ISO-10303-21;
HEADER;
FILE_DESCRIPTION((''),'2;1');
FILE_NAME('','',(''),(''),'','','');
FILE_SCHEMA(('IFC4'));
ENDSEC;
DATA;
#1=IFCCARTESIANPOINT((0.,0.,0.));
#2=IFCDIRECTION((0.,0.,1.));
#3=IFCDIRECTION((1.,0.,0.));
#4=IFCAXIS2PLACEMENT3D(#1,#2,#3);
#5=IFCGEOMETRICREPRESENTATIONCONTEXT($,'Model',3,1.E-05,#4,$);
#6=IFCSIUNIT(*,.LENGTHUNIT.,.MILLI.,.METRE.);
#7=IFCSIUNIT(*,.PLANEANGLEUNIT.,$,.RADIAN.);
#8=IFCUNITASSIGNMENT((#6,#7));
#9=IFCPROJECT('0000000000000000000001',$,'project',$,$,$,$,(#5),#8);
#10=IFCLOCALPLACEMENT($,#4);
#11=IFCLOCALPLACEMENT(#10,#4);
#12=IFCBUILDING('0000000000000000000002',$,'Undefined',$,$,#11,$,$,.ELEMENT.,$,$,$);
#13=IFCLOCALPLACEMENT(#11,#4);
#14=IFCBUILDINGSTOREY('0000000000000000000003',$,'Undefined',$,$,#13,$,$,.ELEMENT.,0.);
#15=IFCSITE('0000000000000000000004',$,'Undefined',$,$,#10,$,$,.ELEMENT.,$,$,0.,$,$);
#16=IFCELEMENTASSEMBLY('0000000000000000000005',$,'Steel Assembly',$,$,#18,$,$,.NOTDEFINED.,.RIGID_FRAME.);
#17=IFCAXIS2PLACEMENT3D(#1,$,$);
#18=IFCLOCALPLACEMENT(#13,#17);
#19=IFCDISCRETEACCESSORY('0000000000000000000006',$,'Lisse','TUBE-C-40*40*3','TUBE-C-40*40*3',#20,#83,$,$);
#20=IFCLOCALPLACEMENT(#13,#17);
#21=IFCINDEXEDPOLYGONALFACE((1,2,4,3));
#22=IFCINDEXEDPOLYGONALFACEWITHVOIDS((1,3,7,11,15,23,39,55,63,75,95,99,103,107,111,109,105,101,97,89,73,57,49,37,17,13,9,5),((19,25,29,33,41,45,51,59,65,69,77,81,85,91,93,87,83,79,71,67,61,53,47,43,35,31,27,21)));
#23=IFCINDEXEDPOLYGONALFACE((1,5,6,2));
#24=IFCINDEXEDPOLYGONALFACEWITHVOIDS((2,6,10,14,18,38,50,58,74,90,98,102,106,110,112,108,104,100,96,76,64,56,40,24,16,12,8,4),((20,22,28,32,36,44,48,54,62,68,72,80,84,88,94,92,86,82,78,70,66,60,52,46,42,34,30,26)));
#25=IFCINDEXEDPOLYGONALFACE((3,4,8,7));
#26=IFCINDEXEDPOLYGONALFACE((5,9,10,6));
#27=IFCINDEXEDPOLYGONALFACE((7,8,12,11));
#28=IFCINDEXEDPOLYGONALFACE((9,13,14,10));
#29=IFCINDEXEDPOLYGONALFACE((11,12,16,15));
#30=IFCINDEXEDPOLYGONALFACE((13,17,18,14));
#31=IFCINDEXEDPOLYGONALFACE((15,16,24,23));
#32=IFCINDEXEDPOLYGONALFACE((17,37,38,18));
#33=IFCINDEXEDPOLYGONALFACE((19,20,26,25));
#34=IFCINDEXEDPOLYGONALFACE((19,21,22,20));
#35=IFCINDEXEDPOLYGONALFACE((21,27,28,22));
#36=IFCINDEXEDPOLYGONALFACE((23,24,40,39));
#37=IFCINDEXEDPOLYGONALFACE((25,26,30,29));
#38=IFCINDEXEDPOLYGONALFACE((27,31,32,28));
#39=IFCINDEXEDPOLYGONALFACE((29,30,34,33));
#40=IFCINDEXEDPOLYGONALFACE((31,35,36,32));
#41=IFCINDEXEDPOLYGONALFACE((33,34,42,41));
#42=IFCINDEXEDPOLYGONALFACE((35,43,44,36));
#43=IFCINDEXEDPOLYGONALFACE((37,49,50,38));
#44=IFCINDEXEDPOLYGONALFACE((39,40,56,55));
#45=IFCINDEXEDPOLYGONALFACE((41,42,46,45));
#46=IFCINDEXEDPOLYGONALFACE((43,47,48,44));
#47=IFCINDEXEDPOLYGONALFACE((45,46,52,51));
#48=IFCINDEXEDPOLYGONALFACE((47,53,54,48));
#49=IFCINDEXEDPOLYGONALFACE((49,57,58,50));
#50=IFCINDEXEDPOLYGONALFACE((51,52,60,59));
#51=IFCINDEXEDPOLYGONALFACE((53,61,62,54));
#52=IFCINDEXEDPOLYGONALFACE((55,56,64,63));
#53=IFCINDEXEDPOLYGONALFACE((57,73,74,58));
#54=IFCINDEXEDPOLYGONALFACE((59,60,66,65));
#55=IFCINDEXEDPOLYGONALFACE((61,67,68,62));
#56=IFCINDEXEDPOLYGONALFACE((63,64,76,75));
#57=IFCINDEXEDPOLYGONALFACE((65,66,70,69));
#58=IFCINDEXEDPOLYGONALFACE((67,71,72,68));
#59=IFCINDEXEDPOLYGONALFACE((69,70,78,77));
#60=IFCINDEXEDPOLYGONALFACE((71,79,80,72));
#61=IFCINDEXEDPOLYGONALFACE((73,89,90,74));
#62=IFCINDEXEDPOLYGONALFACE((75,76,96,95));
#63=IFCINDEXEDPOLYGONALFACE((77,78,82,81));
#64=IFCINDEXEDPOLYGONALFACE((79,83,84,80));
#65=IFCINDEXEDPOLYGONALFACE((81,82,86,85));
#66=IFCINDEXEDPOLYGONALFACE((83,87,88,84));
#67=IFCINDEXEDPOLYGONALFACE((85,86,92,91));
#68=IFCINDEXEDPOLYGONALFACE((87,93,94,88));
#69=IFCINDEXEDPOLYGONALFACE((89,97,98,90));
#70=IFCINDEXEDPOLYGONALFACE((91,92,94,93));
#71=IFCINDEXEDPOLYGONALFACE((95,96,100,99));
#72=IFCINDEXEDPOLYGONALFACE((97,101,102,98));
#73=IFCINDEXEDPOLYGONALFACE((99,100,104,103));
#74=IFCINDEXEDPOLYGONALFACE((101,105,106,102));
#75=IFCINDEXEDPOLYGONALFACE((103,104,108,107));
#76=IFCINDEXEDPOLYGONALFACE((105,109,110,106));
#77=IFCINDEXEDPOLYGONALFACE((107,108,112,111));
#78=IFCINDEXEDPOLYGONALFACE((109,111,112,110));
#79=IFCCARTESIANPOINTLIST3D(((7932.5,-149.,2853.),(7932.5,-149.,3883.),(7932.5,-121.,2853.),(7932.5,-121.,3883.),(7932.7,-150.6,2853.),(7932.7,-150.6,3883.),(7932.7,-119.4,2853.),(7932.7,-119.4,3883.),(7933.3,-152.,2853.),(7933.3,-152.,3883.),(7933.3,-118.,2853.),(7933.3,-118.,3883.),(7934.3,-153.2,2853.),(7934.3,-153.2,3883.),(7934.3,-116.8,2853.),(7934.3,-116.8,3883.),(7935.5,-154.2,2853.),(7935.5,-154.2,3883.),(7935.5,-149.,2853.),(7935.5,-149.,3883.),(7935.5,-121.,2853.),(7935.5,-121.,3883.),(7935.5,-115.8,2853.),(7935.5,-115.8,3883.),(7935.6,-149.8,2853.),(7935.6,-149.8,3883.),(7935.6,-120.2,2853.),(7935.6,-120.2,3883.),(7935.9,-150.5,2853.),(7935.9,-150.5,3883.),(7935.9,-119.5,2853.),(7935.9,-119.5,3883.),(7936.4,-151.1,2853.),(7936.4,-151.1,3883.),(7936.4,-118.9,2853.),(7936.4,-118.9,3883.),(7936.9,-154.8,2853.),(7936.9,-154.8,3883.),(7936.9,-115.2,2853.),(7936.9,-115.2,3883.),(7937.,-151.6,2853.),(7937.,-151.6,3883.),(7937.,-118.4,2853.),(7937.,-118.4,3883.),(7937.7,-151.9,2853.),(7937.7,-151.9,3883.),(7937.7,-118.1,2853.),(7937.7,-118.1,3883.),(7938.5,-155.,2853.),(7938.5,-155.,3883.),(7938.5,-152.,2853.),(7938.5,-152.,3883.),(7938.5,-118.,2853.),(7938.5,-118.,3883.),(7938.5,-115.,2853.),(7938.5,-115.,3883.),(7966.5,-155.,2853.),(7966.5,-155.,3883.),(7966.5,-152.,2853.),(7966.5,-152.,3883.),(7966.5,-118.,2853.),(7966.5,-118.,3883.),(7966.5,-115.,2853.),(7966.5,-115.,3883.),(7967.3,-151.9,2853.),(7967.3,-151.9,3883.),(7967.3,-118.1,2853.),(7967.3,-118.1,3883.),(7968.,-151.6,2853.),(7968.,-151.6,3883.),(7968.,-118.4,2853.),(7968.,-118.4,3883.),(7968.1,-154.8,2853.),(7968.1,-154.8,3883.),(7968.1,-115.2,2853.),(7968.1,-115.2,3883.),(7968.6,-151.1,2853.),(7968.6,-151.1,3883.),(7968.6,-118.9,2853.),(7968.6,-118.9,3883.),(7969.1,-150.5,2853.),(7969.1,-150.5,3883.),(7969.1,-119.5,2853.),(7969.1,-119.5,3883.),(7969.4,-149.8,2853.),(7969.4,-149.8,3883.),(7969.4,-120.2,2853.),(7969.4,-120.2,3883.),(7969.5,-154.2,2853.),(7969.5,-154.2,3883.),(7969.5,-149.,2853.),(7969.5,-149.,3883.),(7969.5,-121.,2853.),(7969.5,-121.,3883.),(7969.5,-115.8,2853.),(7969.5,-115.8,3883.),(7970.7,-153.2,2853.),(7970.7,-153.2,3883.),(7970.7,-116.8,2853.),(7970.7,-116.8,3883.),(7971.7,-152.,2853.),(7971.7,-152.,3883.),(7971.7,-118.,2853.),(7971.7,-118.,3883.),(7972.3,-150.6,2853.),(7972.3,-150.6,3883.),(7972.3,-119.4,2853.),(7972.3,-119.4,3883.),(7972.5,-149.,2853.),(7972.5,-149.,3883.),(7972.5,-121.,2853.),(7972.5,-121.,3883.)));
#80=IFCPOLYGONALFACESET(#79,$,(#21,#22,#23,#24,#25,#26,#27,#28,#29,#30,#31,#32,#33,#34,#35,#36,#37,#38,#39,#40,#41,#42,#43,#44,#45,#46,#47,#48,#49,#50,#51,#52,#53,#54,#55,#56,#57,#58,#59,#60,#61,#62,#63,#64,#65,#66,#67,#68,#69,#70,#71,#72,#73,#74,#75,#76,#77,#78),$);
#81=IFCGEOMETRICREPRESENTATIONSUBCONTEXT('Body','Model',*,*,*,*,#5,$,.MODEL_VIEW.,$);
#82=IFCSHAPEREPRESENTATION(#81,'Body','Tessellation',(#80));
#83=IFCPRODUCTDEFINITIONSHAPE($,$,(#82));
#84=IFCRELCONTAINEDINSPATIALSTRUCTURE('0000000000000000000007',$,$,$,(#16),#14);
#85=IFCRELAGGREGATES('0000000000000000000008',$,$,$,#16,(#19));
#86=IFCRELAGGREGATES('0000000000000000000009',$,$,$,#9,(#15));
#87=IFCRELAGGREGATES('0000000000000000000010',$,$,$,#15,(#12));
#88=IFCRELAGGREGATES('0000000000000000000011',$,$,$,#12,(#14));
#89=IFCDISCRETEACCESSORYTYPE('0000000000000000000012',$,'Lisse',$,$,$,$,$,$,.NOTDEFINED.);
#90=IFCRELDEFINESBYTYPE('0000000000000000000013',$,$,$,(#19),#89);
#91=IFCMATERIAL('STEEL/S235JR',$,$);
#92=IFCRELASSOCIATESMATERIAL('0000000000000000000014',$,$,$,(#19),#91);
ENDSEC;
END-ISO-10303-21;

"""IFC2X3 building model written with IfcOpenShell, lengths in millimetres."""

from ifc_helpers import new_model, si_unit, frame, origin_with_axes, origin_2d_with_axis, place, context, subcontext, project, spatial, hollow_rectangle, extrude, material, type_object, element, aggregate, save


model = new_model("IFC2X3")

# Units and contexts
model_context = context("Model", 3, precision=1e-05, world=origin_with_axes())
body_context = subcontext(model_context, "Body", "Model", "MODEL_VIEW")
ifc_project = project(units=[si_unit("LENGTHUNIT", "METRE", prefix="MILLI"), si_unit("PLANEANGLEUNIT", "RADIAN")], contexts=[model_context])

# Site, building, storey
site_placement = place(None, origin_with_axes())
site = spatial("IfcSite", under=ifc_project, at=site_placement, Name="Undefined", CompositionType="ELEMENT", RefElevation=0.0)
building_placement = place(site_placement, origin_with_axes())
building = spatial("IfcBuilding", under=site, at=building_placement, Name="Undefined", CompositionType="ELEMENT")
storey_placement = place(building_placement, origin_with_axes())
storey = spatial("IfcBuildingStorey", under=building, at=storey_placement, Name="Undefined", CompositionType="ELEMENT", Elevation=0.0)

# Shared definitions
ifc_material_1 = material(Name="STEEL/S235JR")

# Element assembly
assembly_1_placement = place(storey_placement, origin_with_axes())
assembly_1 = element("IfcElementAssembly", 1, at=assembly_1_placement, inside=storey, Name="Steel Assembly", AssemblyPlace="NOTDEFINED", PredefinedType="RIGID_FRAME")

# Discrete accessory
discrete_accessory_type_1 = type_object("IfcDiscreteAccessoryType", Name="Lisse")
discrete_accessory_1_placement = place(assembly_1_placement, frame((7952.5, -135.0, 3883.0), z_axis=(0.0, 1.0, 0.0), x_axis=(0.0, 0.0, -1.0)))
discrete_accessory_1 = element("IfcDiscreteAccessory", 2, at=discrete_accessory_1_placement, type_object=discrete_accessory_type_1, material=ifc_material_1, Name="Lisse", Description="TUBE-C-40*40*3", ObjectType="TUBE-C-40*40*3", context=body_context, shape_type="SweptSolid", body=[
    extrude(hollow_rectangle(XDim=40.0, YDim=40.0, WallThickness=3.0, InnerFilletRadius=3.0, OuterFilletRadius=6.0, at=origin_2d_with_axis()), frame((1030.0, 0.0, 0.0), z_axis=(-1.0, 0.0, 0.0), x_axis=(0.0, -1.0, 0.0)), (0.0, 0.0, 1.0), 1030.0),
])
aggregate(assembly_1, [discrete_accessory_1])

save(model, "model.ifc")
